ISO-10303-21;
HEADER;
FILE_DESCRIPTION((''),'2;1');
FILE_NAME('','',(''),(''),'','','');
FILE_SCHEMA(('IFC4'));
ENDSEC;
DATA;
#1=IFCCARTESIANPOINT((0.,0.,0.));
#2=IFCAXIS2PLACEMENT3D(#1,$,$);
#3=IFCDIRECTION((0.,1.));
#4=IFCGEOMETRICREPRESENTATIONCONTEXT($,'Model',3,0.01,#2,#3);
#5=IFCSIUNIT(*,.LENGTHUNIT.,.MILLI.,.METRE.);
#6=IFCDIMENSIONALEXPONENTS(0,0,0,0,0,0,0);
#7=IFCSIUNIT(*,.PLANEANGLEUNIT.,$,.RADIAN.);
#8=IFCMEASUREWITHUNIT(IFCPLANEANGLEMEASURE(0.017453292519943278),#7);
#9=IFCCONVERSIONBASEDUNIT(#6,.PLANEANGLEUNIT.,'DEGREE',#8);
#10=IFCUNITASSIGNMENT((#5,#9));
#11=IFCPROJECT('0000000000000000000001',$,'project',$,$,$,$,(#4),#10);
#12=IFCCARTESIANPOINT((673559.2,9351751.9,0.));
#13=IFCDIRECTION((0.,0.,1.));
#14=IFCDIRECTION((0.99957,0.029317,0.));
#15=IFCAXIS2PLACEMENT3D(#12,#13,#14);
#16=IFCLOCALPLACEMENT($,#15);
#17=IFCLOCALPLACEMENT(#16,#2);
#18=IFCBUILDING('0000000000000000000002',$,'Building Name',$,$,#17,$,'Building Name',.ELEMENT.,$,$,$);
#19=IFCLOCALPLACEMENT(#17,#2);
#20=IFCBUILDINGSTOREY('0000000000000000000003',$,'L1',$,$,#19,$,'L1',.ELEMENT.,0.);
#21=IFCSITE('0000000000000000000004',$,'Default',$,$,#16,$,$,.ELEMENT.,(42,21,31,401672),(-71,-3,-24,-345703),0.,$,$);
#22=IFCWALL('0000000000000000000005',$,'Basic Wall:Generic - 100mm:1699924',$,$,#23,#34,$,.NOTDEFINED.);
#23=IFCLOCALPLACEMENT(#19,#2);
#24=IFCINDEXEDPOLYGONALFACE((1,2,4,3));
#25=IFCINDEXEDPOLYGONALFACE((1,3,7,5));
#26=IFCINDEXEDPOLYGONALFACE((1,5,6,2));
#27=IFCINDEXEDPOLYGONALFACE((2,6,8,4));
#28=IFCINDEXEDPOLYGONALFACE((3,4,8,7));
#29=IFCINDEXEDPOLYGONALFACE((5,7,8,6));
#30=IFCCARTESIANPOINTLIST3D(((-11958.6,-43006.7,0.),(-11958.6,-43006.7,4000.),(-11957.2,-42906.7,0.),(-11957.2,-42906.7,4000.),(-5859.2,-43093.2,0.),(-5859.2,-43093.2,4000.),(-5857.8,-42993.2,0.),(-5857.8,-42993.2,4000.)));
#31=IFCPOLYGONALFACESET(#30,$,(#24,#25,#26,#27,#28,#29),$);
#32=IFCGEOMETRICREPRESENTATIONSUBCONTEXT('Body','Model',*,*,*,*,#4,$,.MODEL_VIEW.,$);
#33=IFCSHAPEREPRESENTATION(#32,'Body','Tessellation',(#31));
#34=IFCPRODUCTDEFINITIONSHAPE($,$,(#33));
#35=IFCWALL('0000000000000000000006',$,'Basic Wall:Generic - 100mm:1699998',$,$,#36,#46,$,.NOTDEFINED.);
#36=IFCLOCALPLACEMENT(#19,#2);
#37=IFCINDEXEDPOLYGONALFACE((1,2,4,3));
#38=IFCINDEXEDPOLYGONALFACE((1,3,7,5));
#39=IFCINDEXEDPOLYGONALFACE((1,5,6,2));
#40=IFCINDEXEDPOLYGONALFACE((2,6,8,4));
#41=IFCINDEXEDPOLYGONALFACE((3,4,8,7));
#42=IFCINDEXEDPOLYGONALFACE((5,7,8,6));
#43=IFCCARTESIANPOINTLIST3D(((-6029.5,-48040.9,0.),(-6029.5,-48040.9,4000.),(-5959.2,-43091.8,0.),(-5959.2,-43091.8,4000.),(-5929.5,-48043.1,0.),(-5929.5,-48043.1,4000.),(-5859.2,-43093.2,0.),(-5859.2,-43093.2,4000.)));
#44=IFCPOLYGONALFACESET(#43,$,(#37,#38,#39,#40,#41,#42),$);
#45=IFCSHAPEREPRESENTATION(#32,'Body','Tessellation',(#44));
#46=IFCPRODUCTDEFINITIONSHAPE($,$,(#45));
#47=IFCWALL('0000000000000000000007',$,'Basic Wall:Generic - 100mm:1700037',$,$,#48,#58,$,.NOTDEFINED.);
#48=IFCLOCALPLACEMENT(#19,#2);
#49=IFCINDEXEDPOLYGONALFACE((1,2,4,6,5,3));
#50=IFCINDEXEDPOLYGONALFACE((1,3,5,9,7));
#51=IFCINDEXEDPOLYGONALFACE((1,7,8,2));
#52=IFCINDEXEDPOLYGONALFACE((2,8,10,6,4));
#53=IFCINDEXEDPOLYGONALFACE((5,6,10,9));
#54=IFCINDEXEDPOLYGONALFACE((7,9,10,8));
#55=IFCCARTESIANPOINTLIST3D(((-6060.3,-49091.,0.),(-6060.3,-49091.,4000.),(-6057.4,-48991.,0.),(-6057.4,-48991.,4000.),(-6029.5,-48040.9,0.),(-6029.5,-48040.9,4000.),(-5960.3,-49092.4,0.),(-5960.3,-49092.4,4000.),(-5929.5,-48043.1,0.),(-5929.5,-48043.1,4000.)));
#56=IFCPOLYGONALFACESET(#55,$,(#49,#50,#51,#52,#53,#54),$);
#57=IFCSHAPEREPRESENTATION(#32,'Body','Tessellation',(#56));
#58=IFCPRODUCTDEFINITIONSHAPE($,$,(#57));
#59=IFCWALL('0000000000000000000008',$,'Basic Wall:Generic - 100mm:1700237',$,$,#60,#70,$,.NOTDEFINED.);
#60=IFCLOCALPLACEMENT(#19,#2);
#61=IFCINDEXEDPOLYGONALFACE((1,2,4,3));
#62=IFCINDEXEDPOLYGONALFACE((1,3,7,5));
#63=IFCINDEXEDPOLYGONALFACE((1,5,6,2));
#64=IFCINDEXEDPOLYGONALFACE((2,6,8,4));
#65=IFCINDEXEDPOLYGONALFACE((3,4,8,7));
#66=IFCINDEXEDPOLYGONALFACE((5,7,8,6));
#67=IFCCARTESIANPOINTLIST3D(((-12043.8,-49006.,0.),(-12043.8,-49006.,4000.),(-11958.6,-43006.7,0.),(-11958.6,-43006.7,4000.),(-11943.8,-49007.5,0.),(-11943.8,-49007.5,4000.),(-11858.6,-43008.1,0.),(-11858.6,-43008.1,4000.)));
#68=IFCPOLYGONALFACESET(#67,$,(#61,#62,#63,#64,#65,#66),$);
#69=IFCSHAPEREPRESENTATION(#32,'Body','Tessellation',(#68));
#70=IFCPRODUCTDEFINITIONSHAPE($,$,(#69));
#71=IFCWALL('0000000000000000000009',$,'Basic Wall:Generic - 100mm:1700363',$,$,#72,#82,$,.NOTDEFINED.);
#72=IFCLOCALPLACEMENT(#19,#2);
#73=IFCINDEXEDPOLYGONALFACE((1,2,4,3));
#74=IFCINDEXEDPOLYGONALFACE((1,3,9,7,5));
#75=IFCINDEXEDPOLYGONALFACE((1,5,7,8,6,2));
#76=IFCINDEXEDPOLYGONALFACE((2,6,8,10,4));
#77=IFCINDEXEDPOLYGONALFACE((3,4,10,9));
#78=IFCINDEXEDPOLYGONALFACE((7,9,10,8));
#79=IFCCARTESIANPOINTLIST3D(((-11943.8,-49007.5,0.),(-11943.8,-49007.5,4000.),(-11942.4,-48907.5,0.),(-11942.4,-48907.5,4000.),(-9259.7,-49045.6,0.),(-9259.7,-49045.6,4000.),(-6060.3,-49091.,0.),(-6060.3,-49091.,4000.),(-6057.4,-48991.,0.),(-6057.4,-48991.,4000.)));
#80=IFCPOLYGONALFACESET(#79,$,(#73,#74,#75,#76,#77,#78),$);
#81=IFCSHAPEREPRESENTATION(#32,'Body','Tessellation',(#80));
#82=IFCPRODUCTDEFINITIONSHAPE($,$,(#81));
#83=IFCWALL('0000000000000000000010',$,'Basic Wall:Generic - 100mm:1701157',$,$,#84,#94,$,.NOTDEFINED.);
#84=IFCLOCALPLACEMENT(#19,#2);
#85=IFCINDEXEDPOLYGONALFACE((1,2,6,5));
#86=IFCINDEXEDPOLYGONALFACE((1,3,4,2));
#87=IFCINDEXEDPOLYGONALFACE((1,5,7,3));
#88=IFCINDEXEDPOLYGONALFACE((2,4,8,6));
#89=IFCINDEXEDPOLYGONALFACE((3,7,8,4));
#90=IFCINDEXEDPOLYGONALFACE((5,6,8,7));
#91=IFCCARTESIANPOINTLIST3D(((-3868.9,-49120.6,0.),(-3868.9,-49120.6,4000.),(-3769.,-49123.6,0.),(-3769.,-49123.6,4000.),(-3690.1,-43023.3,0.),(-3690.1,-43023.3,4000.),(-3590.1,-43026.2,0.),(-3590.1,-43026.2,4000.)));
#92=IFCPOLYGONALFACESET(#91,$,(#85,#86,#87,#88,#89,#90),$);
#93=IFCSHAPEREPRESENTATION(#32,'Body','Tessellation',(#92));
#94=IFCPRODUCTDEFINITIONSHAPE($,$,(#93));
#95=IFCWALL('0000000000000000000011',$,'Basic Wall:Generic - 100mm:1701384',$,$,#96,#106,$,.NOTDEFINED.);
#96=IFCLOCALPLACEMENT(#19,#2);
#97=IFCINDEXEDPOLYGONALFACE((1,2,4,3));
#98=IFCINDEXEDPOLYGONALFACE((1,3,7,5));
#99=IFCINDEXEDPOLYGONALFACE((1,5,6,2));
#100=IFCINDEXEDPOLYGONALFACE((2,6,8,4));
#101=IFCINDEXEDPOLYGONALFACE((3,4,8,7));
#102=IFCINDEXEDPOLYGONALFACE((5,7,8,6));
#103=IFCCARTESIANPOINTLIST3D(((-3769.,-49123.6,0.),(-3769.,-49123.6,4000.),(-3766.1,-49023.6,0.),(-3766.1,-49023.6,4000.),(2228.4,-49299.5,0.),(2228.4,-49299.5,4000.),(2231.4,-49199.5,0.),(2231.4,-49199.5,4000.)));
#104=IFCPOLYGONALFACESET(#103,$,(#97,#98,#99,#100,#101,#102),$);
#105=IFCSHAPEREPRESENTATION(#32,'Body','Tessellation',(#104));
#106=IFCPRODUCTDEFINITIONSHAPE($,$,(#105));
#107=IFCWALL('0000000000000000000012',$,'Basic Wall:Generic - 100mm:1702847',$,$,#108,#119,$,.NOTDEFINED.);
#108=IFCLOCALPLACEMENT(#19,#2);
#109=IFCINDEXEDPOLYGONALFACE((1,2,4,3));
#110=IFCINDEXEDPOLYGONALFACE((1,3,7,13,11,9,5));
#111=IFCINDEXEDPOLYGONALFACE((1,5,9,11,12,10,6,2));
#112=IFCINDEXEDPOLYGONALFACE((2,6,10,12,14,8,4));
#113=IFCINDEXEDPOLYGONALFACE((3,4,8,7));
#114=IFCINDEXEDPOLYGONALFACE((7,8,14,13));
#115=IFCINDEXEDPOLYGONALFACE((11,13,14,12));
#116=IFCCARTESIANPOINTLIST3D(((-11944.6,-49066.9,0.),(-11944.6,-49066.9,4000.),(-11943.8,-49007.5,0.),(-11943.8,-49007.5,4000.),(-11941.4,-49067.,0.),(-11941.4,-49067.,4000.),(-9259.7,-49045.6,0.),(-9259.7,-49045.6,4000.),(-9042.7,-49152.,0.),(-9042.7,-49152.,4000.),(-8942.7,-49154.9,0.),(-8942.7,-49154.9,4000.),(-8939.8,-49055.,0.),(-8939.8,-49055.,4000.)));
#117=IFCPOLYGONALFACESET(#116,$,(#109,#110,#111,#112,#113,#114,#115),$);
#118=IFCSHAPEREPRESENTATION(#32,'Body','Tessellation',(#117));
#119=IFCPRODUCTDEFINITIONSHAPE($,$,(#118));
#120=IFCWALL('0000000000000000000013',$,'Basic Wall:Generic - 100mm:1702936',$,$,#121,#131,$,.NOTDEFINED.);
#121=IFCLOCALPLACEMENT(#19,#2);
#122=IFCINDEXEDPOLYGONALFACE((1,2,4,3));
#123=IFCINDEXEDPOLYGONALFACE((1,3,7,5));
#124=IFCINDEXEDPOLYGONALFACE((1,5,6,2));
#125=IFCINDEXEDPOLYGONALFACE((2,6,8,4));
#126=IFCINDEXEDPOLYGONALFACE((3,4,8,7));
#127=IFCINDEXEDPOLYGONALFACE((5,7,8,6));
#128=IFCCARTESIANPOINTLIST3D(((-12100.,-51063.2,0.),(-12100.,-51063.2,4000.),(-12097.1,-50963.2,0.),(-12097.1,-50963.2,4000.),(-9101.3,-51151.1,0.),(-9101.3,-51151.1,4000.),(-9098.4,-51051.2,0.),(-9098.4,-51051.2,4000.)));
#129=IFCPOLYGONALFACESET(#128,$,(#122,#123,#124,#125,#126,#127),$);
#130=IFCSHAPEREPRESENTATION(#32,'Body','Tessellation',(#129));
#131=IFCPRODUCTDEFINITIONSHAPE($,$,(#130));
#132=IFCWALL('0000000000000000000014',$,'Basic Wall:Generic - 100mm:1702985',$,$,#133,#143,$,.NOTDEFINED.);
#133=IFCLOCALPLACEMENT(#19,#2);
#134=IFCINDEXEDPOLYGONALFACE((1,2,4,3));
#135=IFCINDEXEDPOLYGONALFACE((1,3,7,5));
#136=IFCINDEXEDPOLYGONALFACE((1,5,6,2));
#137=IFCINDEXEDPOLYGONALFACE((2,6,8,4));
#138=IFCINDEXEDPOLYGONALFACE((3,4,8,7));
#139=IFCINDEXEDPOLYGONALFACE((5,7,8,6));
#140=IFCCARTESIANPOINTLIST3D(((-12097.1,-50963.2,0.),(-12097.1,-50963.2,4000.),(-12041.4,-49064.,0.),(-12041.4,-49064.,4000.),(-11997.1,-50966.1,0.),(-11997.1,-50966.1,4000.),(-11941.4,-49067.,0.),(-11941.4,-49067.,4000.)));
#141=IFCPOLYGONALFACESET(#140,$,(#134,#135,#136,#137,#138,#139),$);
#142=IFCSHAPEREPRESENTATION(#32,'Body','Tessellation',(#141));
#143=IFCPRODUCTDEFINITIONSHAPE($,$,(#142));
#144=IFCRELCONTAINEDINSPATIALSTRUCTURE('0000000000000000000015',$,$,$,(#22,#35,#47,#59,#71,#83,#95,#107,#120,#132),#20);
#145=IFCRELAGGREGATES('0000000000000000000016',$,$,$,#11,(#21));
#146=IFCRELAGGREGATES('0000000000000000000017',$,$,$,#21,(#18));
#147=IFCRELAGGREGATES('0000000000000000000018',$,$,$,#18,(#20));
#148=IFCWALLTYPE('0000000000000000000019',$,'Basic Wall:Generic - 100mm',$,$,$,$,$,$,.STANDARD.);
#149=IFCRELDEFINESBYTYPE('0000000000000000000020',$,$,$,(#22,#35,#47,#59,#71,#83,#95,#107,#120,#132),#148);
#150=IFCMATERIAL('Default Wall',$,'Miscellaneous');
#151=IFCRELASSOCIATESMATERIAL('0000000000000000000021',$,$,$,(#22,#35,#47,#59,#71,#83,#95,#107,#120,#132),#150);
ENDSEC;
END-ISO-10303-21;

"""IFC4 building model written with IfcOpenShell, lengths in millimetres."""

from ifc_helpers import new_model, entity, si_unit, converted_unit, direction, frame, origin, place, context, subcontext, project, spatial, indexed_curve, outline, extrude, material, type_object, element, save


model = new_model("IFC4")

# Units and contexts
model_context = context("Model", 3, precision=0.01, world=origin(), true_north=direction((0.0, 1.0)))
body_context = subcontext(model_context, "Body", "Model", "MODEL_VIEW")
ifc_project = project(units=[si_unit("LENGTHUNIT", "METRE", prefix="MILLI"), converted_unit("PLANEANGLEUNIT", "DEGREE", entity("IfcPlaneAngleMeasure", 0.017453292519943278), si_unit("PLANEANGLEUNIT", "RADIAN"), dimensions=[0, 0, 0, 0, 0, 0, 0])], contexts=[model_context])

# Site, building, storey
site_placement = place(None, frame((673559.2, 9351751.9, 0.0), z_axis=(0.0, 0.0, 1.0), x_axis=(0.99957, 0.029317, 0.0)))
site = spatial("IfcSite", under=ifc_project, at=site_placement, Name="Default", CompositionType="ELEMENT", RefLatitude=(42, 21, 31, 401672), RefLongitude=(-71, -3, -24, -345703), RefElevation=0.0)
building_placement = place(site_placement, origin())
building = spatial("IfcBuilding", under=site, at=building_placement, Name="Building Name", LongName="Building Name", CompositionType="ELEMENT")
storey_placement = place(building_placement, origin())
storey = spatial("IfcBuildingStorey", under=building, at=storey_placement, Name="L1", LongName="L1", CompositionType="ELEMENT", Elevation=0.0)

# Walls
ifc_material_1 = material(Name="Default Wall", Category="Miscellaneous")
wall_type_1 = type_object("IfcWallType", Name="Basic Wall:Generic - 100mm", PredefinedType="STANDARD")
wall_1_placement = place(storey_placement, frame((-11957.9, -42956.7, 0.0), z_axis=(0.0, 0.0, 1.0), x_axis=(0.999899, -0.014195, 0.0)))
element("IfcWall", 1, at=wall_1_placement, inside=storey, type_object=wall_type_1, material=ifc_material_1, Name="Basic Wall:Generic - 100mm:1699924", PredefinedType="NOTDEFINED", context=body_context, shape_type="SweptSolid", body=[
    extrude(outline(indexed_curve([(6100.0, 50.0), (0.0, 50.0), (0.0, -50.0), (6100.0, -50.0), (6100.0, 50.0)], self_intersect=False)), origin(), (0.0, 0.0, 1.0), 4000.0),
])
wall_2_placement = place(storey_placement, frame((-5909.2, -43092.5, 0.0), z_axis=(0.0, 0.0, 1.0), x_axis=(-0.014195, -0.999899, 0.0)))
element("IfcWall", 2, at=wall_2_placement, inside=storey, type_object=wall_type_1, material=ifc_material_1, Name="Basic Wall:Generic - 100mm:1699998", PredefinedType="NOTDEFINED", context=body_context, shape_type="SweptSolid", body=[
    extrude(outline(indexed_curve([(4949.6, -50.0), (4950.4, 50.0), (0.0, 50.0), (0.0, -50.0), (4949.6, -50.0)], self_intersect=False)), origin(), (0.0, 0.0, 1.0), 4000.0),
])
wall_3_placement = place(storey_placement, frame((-5979.5, -48041.7, 0.0), z_axis=(0.0, 0.0, 1.0), x_axis=(-0.029317, -0.99957, 0.0)))
element("IfcWall", 3, at=wall_3_placement, inside=storey, type_object=wall_type_1, material=ifc_material_1, Name="Basic Wall:Generic - 100mm:1700037", PredefinedType="NOTDEFINED", context=body_context, shape_type="SweptSolid", body=[
    extrude(outline(indexed_curve([(1051.3, -50.0), (1049.7, 50.0), (0.0, 50.0), (0.8, -50.0), (951.2, -50.0), (1051.3, -50.0)], self_intersect=False)), origin(), (0.0, 0.0, 1.0), 4000.0),
])
wall_4_placement = place(storey_placement, frame((-11993.8, -49006.8, 0.0), z_axis=(0.0, 0.0, 1.0), x_axis=(0.014195, 0.999899, 0.0)))
element("IfcWall", 4, at=wall_4_placement, inside=storey, type_object=wall_type_1, material=ifc_material_1, Name="Basic Wall:Generic - 100mm:1700237", PredefinedType="NOTDEFINED", context=body_context, shape_type="SweptSolid", body=[
    extrude(outline(indexed_curve([(6000.0, 50.0), (0.0, 50.0), (0.0, -50.0), (6000.0, -50.0), (6000.0, 50.0)], self_intersect=False)), origin(), (0.0, 0.0, 1.0), 4000.0),
])
wall_5_placement = place(storey_placement, frame((-11943.1, -48957.5, 0.0), z_axis=(0.0, 0.0, 1.0), x_axis=(0.999899, -0.014195, 0.0)))
element("IfcWall", 5, at=wall_5_placement, inside=storey, type_object=wall_type_1, material=ifc_material_1, Name="Basic Wall:Generic - 100mm:1700363", PredefinedType="NOTDEFINED", context=body_context, shape_type="SweptSolid", body=[
    extrude(outline(indexed_curve([(5884.1, -50.0), (5885.6, 50.0), (0.0, 50.0), (0.0, -50.0), (2684.4, -50.0), (5884.1, -50.0)], self_intersect=False)), origin(), (0.0, 0.0, 1.0), 4000.0),
])
wall_6_placement = place(storey_placement, frame((-3640.1, -43024.7, 0.0), z_axis=(0.0, 0.0, 1.0), x_axis=(-0.029317, -0.99957, 0.0)))
element("IfcWall", 6, at=wall_6_placement, inside=storey, type_object=wall_type_1, material=ifc_material_1, Name="Basic Wall:Generic - 100mm:1701157", PredefinedType="NOTDEFINED", context=body_context, shape_type="SweptSolid", body=[
    extrude(outline(indexed_curve([(6100.0, 50.0), (0.0, 50.0), (0.0, -50.0), (6100.0, -50.0), (6100.0, 50.0)], self_intersect=False)), origin(), (0.0, 0.0, 1.0), 4000.0),
])
wall_7_placement = place(storey_placement, frame((-3767.5, -49073.6, 0.0), z_axis=(0.0, 0.0, 1.0), x_axis=(0.99957, -0.029317, 0.0)))
element("IfcWall", 7, at=wall_7_placement, inside=storey, type_object=wall_type_1, material=ifc_material_1, Name="Basic Wall:Generic - 100mm:1701384", PredefinedType="NOTDEFINED", context=body_context, shape_type="SweptSolid", body=[
    extrude(outline(indexed_curve([(6000.0, 50.0), (0.0, 50.0), (0.0, -50.0), (6000.0, -50.0), (6000.0, 50.0)], self_intersect=False)), origin(), (0.0, 0.0, 1.0), 4000.0),
])
wall_8_placement = place(storey_placement, frame((-11943.2, -49016.9, 0.0), z_axis=(0.0, 0.0, 1.0), x_axis=(0.99957, -0.029317, 0.0)))
element("IfcWall", 8, at=wall_8_placement, inside=storey, type_object=wall_type_1, material=ifc_material_1, Name="Basic Wall:Generic - 100mm:1702847", PredefinedType="NOTDEFINED", context=body_context, shape_type="SweptSolid", body=[
    extrude(outline(indexed_curve([(3003.2, -50.0), (3003.2, 50.0), (2683.2, 50.0), (-0.9, 9.4), (0.0, -50.0), (3.2, -50.0), (2903.2, -50.0), (3003.2, -50.0)], self_intersect=False)), origin(), (0.0, 0.0, 1.0), 4000.0),
])
wall_9_placement = place(storey_placement, frame((-9099.9, -51101.1, 0.0), z_axis=(0.0, 0.0, 1.0), x_axis=(-0.99957, 0.029317, 0.0)))
element("IfcWall", 9, at=wall_9_placement, inside=storey, type_object=wall_type_1, material=ifc_material_1, Name="Basic Wall:Generic - 100mm:1702936", PredefinedType="NOTDEFINED", context=body_context, shape_type="SweptSolid", body=[
    extrude(outline(indexed_curve([(3000.0, 50.0), (0.0, 50.0), (0.0, -50.0), (3000.0, -50.0), (3000.0, 50.0)], self_intersect=False)), origin(), (0.0, 0.0, 1.0), 4000.0),
])
wall_10_placement = place(storey_placement, frame((-12047.1, -50964.7, 0.0), z_axis=(0.0, 0.0, 1.0), x_axis=(0.029317, 0.99957, 0.0)))
element("IfcWall", 10, at=wall_10_placement, inside=storey, type_object=wall_type_1, material=ifc_material_1, Name="Basic Wall:Generic - 100mm:1702985", PredefinedType="NOTDEFINED", context=body_context, shape_type="SweptSolid", body=[
    extrude(outline(indexed_curve([(1900.0, 50.0), (0.0, 50.0), (0.0, -50.0), (1900.0, -50.0), (1900.0, 50.0)], self_intersect=False)), origin(), (0.0, 0.0, 1.0), 4000.0),
])

save(model, "model.ifc")
